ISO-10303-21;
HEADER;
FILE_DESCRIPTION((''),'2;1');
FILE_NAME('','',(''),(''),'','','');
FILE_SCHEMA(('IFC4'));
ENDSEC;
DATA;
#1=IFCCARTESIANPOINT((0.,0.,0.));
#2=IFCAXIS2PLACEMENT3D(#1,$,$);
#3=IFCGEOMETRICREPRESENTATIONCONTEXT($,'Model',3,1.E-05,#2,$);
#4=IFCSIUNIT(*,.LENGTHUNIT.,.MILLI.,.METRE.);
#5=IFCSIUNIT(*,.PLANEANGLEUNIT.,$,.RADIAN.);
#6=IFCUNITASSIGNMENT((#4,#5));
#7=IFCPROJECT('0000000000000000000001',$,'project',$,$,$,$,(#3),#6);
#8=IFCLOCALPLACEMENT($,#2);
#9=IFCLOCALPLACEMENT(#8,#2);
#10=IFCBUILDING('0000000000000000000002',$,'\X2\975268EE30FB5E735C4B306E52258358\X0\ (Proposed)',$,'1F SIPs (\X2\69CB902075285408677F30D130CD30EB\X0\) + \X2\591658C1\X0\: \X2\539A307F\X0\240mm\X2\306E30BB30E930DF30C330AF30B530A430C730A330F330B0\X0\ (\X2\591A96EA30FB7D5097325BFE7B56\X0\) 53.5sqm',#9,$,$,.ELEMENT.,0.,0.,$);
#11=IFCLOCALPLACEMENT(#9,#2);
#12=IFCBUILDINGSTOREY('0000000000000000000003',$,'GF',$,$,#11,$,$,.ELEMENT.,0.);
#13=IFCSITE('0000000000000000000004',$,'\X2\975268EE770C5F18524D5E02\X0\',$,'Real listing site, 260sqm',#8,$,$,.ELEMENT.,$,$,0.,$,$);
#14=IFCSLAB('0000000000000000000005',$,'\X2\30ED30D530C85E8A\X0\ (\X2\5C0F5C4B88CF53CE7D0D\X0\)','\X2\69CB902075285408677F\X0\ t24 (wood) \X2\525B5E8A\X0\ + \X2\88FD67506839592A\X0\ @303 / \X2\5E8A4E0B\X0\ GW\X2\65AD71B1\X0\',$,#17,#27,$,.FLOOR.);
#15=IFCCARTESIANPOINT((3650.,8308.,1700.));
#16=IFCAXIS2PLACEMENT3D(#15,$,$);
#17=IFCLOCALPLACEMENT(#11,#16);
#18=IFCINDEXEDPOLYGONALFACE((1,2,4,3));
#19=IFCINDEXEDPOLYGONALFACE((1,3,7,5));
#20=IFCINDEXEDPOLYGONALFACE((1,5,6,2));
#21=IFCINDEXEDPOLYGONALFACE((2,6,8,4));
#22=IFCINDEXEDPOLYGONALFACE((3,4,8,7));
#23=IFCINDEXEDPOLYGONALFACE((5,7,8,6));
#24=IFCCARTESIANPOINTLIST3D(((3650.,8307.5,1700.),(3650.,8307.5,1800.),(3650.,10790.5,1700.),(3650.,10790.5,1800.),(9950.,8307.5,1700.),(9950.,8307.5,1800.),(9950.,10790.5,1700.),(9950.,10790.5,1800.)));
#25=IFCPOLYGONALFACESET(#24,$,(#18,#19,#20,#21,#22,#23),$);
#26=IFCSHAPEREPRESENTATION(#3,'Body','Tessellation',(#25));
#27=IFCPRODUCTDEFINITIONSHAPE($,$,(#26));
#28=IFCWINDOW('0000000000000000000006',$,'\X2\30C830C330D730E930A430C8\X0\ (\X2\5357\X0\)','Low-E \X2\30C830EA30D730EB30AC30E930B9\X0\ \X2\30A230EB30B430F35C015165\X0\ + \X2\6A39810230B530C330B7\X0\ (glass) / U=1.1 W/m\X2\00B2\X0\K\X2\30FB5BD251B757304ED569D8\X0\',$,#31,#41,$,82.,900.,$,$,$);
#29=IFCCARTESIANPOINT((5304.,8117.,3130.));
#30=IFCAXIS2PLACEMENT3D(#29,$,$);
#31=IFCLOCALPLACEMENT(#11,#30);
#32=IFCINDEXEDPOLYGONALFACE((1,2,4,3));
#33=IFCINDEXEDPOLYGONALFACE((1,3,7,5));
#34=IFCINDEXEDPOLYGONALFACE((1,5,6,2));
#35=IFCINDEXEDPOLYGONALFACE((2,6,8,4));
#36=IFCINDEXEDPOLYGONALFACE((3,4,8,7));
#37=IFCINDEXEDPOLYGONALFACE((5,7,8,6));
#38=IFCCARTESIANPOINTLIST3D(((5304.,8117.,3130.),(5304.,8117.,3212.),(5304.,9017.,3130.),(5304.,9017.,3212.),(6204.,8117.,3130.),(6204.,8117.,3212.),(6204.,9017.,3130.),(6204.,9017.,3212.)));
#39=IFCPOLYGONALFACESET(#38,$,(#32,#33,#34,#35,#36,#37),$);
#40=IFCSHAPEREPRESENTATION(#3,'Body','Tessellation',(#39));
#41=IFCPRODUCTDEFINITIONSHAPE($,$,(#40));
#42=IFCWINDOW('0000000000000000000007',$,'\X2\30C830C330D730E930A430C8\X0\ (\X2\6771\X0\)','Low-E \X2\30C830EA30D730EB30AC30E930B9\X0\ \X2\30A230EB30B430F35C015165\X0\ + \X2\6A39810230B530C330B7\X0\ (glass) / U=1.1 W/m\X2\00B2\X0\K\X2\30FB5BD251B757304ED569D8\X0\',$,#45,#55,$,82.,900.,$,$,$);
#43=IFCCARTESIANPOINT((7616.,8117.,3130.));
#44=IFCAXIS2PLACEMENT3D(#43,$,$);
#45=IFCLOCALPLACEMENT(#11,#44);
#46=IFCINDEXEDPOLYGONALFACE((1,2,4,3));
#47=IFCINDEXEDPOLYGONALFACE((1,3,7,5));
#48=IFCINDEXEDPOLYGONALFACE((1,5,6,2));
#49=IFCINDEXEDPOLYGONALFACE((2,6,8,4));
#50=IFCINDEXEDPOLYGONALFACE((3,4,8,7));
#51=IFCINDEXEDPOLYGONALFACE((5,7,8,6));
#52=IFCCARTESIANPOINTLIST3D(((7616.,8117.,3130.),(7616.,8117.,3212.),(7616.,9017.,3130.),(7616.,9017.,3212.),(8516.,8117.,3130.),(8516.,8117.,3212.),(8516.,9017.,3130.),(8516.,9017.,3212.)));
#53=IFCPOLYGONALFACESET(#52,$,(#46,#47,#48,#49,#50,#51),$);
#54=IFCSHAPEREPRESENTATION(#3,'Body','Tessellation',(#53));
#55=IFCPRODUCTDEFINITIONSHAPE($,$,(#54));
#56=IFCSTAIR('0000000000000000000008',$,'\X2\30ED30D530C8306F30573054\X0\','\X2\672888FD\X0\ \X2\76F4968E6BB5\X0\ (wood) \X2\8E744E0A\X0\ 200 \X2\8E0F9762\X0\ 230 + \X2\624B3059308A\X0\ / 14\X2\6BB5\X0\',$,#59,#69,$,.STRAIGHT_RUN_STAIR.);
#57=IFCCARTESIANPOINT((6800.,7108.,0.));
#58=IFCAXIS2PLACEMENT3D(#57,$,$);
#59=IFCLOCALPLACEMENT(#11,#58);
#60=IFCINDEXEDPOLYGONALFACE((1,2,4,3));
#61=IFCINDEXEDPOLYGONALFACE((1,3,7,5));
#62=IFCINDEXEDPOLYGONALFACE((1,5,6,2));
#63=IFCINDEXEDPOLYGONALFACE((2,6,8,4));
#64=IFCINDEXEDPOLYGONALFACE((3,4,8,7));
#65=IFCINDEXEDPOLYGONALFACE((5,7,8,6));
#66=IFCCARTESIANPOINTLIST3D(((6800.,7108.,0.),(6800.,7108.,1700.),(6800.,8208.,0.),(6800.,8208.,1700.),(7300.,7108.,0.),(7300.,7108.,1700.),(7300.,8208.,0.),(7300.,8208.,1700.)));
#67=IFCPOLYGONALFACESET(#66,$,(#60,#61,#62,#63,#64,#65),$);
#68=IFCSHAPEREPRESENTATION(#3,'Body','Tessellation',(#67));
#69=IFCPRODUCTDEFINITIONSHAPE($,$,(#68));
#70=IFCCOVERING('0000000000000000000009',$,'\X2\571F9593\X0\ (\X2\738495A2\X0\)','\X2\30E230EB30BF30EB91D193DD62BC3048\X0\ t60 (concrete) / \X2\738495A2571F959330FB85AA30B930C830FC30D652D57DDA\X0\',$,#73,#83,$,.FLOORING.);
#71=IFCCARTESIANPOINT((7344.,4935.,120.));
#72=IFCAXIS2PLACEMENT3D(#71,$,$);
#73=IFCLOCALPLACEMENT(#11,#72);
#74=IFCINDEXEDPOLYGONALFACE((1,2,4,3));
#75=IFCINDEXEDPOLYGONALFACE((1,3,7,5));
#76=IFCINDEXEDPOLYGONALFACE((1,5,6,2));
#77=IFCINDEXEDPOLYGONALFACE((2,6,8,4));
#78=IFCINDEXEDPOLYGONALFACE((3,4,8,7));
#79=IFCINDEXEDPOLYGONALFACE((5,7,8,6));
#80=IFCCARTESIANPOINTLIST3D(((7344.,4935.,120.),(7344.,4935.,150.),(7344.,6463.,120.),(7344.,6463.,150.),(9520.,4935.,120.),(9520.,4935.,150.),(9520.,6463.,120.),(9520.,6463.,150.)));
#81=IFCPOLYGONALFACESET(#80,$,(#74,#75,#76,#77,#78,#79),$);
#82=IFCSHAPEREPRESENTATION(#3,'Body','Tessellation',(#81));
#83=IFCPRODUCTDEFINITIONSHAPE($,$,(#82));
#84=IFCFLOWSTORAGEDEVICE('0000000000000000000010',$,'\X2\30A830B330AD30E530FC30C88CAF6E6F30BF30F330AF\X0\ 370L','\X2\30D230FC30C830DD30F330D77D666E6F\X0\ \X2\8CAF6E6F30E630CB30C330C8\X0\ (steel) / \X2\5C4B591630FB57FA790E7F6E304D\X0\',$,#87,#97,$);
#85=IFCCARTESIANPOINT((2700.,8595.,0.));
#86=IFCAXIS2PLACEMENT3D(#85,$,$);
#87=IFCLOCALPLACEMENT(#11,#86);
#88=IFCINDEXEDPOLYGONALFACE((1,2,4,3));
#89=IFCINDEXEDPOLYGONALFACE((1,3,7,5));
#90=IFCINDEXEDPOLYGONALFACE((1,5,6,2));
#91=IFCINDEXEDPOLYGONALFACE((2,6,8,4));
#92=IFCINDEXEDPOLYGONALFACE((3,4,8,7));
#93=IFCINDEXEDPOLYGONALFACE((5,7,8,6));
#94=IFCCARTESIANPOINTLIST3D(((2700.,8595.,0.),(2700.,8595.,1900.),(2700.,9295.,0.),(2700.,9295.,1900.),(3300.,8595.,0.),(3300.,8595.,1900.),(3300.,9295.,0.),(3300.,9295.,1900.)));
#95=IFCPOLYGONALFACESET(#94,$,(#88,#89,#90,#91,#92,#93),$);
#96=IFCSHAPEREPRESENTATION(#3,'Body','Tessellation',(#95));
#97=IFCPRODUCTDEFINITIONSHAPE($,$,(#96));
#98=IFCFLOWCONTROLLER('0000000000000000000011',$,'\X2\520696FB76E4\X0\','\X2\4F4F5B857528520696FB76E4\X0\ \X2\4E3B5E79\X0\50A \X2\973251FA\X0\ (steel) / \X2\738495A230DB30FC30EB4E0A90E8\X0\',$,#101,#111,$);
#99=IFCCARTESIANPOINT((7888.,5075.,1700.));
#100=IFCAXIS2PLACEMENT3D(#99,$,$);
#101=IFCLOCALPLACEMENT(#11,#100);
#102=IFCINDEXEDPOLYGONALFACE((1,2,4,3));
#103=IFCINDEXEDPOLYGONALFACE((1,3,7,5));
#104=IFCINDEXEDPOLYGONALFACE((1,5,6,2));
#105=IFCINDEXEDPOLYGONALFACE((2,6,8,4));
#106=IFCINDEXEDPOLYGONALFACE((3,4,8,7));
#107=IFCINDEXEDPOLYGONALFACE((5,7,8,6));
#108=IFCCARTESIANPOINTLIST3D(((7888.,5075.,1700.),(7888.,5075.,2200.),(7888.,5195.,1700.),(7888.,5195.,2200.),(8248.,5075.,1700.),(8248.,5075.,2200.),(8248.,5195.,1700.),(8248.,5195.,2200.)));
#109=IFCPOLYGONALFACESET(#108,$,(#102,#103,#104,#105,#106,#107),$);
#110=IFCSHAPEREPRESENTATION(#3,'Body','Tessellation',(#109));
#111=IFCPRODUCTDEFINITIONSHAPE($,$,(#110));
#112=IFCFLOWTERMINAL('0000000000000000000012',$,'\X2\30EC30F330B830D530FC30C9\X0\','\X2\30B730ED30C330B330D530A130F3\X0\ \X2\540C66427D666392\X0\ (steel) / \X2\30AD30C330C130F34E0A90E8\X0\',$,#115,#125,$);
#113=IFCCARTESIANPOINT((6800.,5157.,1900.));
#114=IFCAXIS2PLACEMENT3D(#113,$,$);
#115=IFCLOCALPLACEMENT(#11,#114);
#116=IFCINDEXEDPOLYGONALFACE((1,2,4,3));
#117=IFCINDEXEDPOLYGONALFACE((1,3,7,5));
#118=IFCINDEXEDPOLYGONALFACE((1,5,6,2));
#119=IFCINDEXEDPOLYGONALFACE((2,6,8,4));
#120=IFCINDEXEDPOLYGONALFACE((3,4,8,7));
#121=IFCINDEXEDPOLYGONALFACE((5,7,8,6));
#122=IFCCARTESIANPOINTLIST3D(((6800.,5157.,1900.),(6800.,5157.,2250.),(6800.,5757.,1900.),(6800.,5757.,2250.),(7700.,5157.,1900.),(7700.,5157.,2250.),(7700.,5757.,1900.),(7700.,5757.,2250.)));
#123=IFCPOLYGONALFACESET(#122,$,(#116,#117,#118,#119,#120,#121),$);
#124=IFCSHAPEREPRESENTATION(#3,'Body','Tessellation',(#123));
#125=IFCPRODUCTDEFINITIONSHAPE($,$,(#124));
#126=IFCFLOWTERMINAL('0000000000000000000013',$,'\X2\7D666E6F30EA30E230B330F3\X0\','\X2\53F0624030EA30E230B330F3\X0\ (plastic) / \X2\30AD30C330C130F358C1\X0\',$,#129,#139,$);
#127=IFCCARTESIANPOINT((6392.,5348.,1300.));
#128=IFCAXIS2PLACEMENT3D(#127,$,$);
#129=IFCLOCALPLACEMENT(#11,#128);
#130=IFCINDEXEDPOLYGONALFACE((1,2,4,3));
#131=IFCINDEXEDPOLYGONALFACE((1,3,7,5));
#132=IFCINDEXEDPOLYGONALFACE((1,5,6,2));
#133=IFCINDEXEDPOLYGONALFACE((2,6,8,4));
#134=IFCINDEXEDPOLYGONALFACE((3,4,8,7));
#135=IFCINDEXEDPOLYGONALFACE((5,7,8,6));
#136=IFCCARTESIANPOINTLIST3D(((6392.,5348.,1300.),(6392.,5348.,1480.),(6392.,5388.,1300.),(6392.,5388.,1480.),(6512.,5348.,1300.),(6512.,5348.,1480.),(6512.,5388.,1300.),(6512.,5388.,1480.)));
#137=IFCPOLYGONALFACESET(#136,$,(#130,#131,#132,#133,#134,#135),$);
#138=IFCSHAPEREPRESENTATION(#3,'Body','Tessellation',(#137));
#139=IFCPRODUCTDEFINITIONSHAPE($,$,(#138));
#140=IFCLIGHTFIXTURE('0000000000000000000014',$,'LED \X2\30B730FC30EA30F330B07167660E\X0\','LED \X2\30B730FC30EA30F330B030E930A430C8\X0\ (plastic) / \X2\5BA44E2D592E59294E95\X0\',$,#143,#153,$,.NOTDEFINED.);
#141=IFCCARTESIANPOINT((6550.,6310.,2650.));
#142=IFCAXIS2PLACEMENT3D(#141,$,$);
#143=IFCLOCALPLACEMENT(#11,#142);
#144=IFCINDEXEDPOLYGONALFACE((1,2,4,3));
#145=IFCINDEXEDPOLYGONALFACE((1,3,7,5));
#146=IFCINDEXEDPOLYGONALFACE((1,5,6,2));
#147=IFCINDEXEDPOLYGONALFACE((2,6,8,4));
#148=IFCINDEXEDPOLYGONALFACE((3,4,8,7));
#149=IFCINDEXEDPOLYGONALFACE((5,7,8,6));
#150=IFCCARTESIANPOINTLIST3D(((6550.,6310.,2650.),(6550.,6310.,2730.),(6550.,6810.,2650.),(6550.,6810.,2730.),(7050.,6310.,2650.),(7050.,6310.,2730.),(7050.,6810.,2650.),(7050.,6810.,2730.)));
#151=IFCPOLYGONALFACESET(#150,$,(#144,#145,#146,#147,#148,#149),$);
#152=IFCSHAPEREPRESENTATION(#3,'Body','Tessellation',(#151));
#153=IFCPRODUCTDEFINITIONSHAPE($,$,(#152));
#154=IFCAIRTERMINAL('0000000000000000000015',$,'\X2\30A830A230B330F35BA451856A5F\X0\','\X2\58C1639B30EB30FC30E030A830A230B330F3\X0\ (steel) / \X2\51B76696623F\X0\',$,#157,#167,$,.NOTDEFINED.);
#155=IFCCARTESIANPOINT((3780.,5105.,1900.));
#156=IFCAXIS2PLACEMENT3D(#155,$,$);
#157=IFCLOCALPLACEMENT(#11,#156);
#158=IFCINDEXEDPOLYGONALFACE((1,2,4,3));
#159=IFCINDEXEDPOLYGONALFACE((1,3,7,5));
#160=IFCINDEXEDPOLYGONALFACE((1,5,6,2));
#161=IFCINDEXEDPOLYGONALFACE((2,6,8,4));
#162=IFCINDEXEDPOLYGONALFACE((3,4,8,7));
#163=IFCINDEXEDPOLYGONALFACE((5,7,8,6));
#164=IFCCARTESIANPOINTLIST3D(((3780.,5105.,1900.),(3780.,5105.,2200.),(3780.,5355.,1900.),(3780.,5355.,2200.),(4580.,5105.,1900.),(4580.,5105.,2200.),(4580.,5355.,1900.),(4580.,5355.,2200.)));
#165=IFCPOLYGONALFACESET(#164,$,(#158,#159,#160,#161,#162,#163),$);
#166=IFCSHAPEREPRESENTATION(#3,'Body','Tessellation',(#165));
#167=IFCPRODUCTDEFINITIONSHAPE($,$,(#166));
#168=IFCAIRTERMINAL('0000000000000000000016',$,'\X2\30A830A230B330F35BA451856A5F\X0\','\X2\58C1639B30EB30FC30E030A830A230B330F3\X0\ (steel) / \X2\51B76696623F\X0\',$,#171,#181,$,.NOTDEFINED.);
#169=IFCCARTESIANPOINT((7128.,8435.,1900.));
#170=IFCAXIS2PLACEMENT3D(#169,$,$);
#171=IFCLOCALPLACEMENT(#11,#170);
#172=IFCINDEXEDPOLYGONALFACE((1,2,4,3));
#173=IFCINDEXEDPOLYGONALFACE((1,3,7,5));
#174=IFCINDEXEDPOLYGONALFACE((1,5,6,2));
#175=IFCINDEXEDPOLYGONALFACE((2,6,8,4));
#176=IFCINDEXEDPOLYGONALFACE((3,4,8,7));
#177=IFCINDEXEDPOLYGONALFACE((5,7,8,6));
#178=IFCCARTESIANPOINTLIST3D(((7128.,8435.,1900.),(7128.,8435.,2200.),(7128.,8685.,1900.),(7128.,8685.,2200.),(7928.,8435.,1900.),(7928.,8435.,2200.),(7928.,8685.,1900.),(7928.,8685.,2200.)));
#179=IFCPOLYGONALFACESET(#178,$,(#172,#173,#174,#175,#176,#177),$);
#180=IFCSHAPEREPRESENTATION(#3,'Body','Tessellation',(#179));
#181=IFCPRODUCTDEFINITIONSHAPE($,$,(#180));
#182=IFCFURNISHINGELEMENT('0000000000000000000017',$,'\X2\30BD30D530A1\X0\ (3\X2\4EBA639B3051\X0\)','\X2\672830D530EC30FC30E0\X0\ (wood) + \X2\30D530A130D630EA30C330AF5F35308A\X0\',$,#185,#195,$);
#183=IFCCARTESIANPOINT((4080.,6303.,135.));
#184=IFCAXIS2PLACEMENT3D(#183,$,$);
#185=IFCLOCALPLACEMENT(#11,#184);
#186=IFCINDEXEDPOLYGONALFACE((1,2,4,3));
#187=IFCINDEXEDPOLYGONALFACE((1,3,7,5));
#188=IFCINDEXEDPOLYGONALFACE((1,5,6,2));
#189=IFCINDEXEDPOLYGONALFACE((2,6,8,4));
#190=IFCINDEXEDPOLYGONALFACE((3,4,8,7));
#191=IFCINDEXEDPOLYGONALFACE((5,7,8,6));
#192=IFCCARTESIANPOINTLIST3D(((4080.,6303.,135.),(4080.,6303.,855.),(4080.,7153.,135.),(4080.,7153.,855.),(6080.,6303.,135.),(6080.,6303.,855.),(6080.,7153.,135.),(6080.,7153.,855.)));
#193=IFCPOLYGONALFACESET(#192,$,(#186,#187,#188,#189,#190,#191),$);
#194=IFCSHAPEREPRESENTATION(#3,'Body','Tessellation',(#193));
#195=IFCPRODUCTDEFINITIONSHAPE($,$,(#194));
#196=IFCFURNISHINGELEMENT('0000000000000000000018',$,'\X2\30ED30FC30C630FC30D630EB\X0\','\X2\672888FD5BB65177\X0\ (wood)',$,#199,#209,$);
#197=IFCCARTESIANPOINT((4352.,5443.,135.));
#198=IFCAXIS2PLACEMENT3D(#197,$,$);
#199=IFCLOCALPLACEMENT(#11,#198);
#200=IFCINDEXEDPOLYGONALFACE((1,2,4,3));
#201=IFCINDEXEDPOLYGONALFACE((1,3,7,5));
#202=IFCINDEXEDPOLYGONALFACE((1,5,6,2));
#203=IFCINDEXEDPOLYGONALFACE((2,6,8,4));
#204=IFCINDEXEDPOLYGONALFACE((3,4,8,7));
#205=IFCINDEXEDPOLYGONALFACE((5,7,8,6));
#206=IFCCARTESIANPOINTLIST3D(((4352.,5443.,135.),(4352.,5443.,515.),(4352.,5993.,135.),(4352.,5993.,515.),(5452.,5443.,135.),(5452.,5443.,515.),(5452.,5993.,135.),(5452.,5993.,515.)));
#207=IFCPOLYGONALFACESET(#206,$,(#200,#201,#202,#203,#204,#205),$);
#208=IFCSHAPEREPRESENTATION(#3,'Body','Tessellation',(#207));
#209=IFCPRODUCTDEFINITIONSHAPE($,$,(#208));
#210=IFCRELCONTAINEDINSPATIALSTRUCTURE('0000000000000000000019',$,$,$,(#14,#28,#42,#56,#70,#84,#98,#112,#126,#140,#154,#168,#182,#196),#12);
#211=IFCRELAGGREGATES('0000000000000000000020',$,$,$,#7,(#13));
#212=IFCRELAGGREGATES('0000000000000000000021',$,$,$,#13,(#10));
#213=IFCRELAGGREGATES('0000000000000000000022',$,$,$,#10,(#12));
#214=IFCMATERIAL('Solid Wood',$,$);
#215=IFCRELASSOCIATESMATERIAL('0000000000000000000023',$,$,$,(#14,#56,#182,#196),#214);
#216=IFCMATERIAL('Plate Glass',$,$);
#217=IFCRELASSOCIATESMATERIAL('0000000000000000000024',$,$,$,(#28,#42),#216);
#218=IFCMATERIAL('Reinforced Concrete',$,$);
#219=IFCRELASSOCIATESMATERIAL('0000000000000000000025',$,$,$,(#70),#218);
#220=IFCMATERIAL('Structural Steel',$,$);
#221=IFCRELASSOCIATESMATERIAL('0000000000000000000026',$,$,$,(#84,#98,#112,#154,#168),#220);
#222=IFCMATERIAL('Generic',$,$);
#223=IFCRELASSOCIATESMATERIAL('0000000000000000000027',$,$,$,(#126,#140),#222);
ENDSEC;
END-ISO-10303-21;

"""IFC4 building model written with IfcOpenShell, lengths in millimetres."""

from ifc_helpers import new_model, si_unit, frame, frame_2d, origin, place, context, project, spatial, rectangle, extrude, material, element, save


model = new_model("IFC4")

# Units and contexts
model_context = context("Model", 3, precision=1e-05, world=origin())
ifc_project = project(units=[si_unit("LENGTHUNIT", "METRE", prefix="MILLI"), si_unit("PLANEANGLEUNIT", "RADIAN")], contexts=[model_context])

# Site, building, storey
site_placement = place(None, origin())
site = spatial("IfcSite", under=ifc_project, at=site_placement, Name="青森県弘前市", ObjectType="Real listing site, 260sqm", CompositionType="ELEMENT", RefElevation=0.0)
building_placement = place(site_placement, origin())
building = spatial("IfcBuilding", under=site, at=building_placement, Name="青森・平屋の別荘 (Proposed)", ObjectType="1F SIPs (構造用合板パネル) + 外壁: 厚み240mmのセラミックサイディング (多雪・結露対策) 53.5sqm", CompositionType="ELEMENT", ElevationOfRefHeight=0.0, ElevationOfTerrain=0.0)
storey_placement = place(building_placement, origin())
storey = spatial("IfcBuildingStorey", under=building, at=storey_placement, Name="GF", CompositionType="ELEMENT", Elevation=0.0)

# Shared definitions
ifc_material_1 = material(Name="Solid Wood")

# Slab
slab_placement = place(storey_placement, frame((3650.0, 8308.0, 1700.0)))
element("IfcSlab", 1, at=slab_placement, inside=storey, material=ifc_material_1, Name="ロフト床 (小屋裏収納)", Description="構造用合板 t24 (wood) 剛床 + 製材根太 @303 / 床下 GW断熱", PredefinedType="FLOOR", context=model_context, shape_type="SweptSolid", body=[
    extrude(rectangle(XDim=6300.0, YDim=2483.0, at=frame_2d((3150.0, 1241.0))), frame((3650.0, 8308.0, 1700.0)), (0.0, 0.0, 1.0), 100.0),
])

# Windows
ifc_material_2 = material(Name="Plate Glass")
window_1_placement = place(storey_placement, frame((5304.0, 8117.0, 3130.0)))
element("IfcWindow", 2, at=window_1_placement, inside=storey, material=ifc_material_2, Name="トップライト (南)", Description="Low-E トリプルガラス アルゴン封入 + 樹脂サッシ (glass) / U=1.1 W/m²K・寒冷地仕様", OverallHeight=82.0, OverallWidth=900.0, context=model_context, shape_type="SweptSolid", body=[
    extrude(rectangle(XDim=900.0, YDim=900.0, at=frame_2d((450.0, 450.0))), frame((5304.0, 8117.0, 3130.0)), (0.0, 0.0, 1.0), 82.0),
])
window_2_placement = place(storey_placement, frame((7616.0, 8117.0, 3130.0)))
element("IfcWindow", 3, at=window_2_placement, inside=storey, material=ifc_material_2, Name="トップライト (東)", Description="Low-E トリプルガラス アルゴン封入 + 樹脂サッシ (glass) / U=1.1 W/m²K・寒冷地仕様", OverallHeight=82.0, OverallWidth=900.0, context=model_context, shape_type="SweptSolid", body=[
    extrude(rectangle(XDim=900.0, YDim=900.0, at=frame_2d((450.0, 450.0))), frame((7616.0, 8117.0, 3130.0)), (0.0, 0.0, 1.0), 82.0),
])

# Stair
stair_placement = place(storey_placement, frame((6800.0, 7108.0, 0.0)))
element("IfcStair", 4, at=stair_placement, inside=storey, material=ifc_material_1, Name="ロフトはしご", Description="木製 直階段 (wood) 蹴上 200 踏面 230 + 手すり / 14段", PredefinedType="STRAIGHT_RUN_STAIR", context=model_context, shape_type="SweptSolid", body=[
    extrude(rectangle(XDim=500.0, YDim=1100.0, at=frame_2d((250.0, 550.0))), frame((6800.0, 7108.0, 0.0)), (0.0, 0.0, 1.0), 1700.0),
])

# Covering
ifc_material_3 = material(Name="Reinforced Concrete")
covering_placement = place(storey_placement, frame((7344.0, 4935.0, 120.0)))
element("IfcCovering", 5, at=covering_placement, inside=storey, material=ifc_material_3, Name="土間 (玄関)", Description="モルタル金鏝押え t60 (concrete) / 玄関土間・薪ストーブ動線", PredefinedType="FLOORING", context=model_context, shape_type="SweptSolid", body=[
    extrude(rectangle(XDim=2176.0, YDim=1528.0, at=frame_2d((1088.0, 764.0))), frame((7344.0, 4935.0, 120.0)), (0.0, 0.0, 1.0), 30.0),
])

# Flow storage device
ifc_material_4 = material(Name="Structural Steel")
flow_storage_device_placement = place(storey_placement, frame((2700.0, 8595.0, 0.0)))
element("IfcFlowStorageDevice", 6, at=flow_storage_device_placement, inside=storey, material=ifc_material_4, Name="エコキュート貯湯タンク 370L", Description="ヒートポンプ給湯 貯湯ユニット (steel) / 屋外・基礎置き", context=model_context, shape_type="SweptSolid", body=[
    extrude(rectangle(XDim=600.0, YDim=700.0, at=frame_2d((300.0, 350.0))), frame((2700.0, 8595.0, 0.0)), (0.0, 0.0, 1.0), 1900.0),
])

# Flow controller
flow_controller_placement = place(storey_placement, frame((7888.0, 5075.0, 1700.0)))
element("IfcFlowController", 7, at=flow_controller_placement, inside=storey, material=ifc_material_4, Name="分電盤", Description="住宅用分電盤 主幹50A 露出 (steel) / 玄関ホール上部", context=model_context, shape_type="SweptSolid", body=[
    extrude(rectangle(XDim=360.0, YDim=120.0, at=frame_2d((180.0, 60.0))), frame((7888.0, 5075.0, 1700.0)), (0.0, 0.0, 1.0), 500.0),
])

# Flow terminals
flow_terminal_1_placement = place(storey_placement, frame((6800.0, 5157.0, 1900.0)))
element("IfcFlowTerminal", 8, at=flow_terminal_1_placement, inside=storey, material=ifc_material_4, Name="レンジフード", Description="シロッコファン 同時給排 (steel) / キッチン上部", context=model_context, shape_type="SweptSolid", body=[
    extrude(rectangle(XDim=900.0, YDim=600.0, at=frame_2d((450.0, 300.0))), frame((6800.0, 5157.0, 1900.0)), (0.0, 0.0, 1.0), 350.0),
])
ifc_material_5 = material(Name="Generic")
flow_terminal_2_placement = place(storey_placement, frame((6392.0, 5348.0, 1300.0)))
element("IfcFlowTerminal", 9, at=flow_terminal_2_placement, inside=storey, material=ifc_material_5, Name="給湯リモコン", Description="台所リモコン (plastic) / キッチン壁", context=model_context, shape_type="SweptSolid", body=[
    extrude(rectangle(XDim=120.0, YDim=40.0, at=frame_2d((60.0, 20.0))), frame((6392.0, 5348.0, 1300.0)), (0.0, 0.0, 1.0), 180.0),
])

# Light fixture
light_fixture_placement = place(storey_placement, frame((6550.0, 6310.0, 2650.0)))
element("IfcLightFixture", 10, at=light_fixture_placement, inside=storey, material=ifc_material_5, Name="LED シーリング照明", Description="LED シーリングライト (plastic) / 室中央天井", PredefinedType="NOTDEFINED", context=model_context, shape_type="SweptSolid", body=[
    extrude(rectangle(XDim=500.0, YDim=500.0, at=frame_2d((250.0, 250.0))), frame((6550.0, 6310.0, 2650.0)), (0.0, 0.0, 1.0), 80.0),
])

# Air terminals
air_terminal_1_placement = place(storey_placement, frame((3780.0, 5105.0, 1900.0)))
element("IfcAirTerminal", 11, at=air_terminal_1_placement, inside=storey, material=ifc_material_4, Name="エアコン室内機", Description="壁掛ルームエアコン (steel) / 冷暖房", PredefinedType="NOTDEFINED", context=model_context, shape_type="SweptSolid", body=[
    extrude(rectangle(XDim=800.0, YDim=250.0, at=frame_2d((400.0, 125.0))), frame((3780.0, 5105.0, 1900.0)), (0.0, 0.0, 1.0), 300.0),
])
air_terminal_2_placement = place(storey_placement, frame((7128.0, 8435.0, 1900.0)))
element("IfcAirTerminal", 12, at=air_terminal_2_placement, inside=storey, material=ifc_material_4, Name="エアコン室内機", Description="壁掛ルームエアコン (steel) / 冷暖房", PredefinedType="NOTDEFINED", context=model_context, shape_type="SweptSolid", body=[
    extrude(rectangle(XDim=800.0, YDim=250.0, at=frame_2d((400.0, 125.0))), frame((7128.0, 8435.0, 1900.0)), (0.0, 0.0, 1.0), 300.0),
])

# Furnishing elements
furnishing_1_placement = place(storey_placement, frame((4080.0, 6303.0, 135.0)))
element("IfcFurnishingElement", 13, at=furnishing_1_placement, inside=storey, material=ifc_material_1, Name="ソファ (3人掛け)", Description="木フレーム (wood) + ファブリック張り", context=model_context, shape_type="SweptSolid", body=[
    extrude(rectangle(XDim=2000.0, YDim=850.0, at=frame_2d((1000.0, 425.0))), frame((4080.0, 6303.0, 135.0)), (0.0, 0.0, 1.0), 720.0),
])
furnishing_2_placement = place(storey_placement, frame((4352.0, 5443.0, 135.0)))
element("IfcFurnishingElement", 14, at=furnishing_2_placement, inside=storey, material=ifc_material_1, Name="ローテーブル", Description="木製家具 (wood)", context=model_context, shape_type="SweptSolid", body=[
    extrude(rectangle(XDim=1100.0, YDim=550.0, at=frame_2d((550.0, 275.0))), frame((4352.0, 5443.0, 135.0)), (0.0, 0.0, 1.0), 380.0),
])

save(model, "model.ifc")
